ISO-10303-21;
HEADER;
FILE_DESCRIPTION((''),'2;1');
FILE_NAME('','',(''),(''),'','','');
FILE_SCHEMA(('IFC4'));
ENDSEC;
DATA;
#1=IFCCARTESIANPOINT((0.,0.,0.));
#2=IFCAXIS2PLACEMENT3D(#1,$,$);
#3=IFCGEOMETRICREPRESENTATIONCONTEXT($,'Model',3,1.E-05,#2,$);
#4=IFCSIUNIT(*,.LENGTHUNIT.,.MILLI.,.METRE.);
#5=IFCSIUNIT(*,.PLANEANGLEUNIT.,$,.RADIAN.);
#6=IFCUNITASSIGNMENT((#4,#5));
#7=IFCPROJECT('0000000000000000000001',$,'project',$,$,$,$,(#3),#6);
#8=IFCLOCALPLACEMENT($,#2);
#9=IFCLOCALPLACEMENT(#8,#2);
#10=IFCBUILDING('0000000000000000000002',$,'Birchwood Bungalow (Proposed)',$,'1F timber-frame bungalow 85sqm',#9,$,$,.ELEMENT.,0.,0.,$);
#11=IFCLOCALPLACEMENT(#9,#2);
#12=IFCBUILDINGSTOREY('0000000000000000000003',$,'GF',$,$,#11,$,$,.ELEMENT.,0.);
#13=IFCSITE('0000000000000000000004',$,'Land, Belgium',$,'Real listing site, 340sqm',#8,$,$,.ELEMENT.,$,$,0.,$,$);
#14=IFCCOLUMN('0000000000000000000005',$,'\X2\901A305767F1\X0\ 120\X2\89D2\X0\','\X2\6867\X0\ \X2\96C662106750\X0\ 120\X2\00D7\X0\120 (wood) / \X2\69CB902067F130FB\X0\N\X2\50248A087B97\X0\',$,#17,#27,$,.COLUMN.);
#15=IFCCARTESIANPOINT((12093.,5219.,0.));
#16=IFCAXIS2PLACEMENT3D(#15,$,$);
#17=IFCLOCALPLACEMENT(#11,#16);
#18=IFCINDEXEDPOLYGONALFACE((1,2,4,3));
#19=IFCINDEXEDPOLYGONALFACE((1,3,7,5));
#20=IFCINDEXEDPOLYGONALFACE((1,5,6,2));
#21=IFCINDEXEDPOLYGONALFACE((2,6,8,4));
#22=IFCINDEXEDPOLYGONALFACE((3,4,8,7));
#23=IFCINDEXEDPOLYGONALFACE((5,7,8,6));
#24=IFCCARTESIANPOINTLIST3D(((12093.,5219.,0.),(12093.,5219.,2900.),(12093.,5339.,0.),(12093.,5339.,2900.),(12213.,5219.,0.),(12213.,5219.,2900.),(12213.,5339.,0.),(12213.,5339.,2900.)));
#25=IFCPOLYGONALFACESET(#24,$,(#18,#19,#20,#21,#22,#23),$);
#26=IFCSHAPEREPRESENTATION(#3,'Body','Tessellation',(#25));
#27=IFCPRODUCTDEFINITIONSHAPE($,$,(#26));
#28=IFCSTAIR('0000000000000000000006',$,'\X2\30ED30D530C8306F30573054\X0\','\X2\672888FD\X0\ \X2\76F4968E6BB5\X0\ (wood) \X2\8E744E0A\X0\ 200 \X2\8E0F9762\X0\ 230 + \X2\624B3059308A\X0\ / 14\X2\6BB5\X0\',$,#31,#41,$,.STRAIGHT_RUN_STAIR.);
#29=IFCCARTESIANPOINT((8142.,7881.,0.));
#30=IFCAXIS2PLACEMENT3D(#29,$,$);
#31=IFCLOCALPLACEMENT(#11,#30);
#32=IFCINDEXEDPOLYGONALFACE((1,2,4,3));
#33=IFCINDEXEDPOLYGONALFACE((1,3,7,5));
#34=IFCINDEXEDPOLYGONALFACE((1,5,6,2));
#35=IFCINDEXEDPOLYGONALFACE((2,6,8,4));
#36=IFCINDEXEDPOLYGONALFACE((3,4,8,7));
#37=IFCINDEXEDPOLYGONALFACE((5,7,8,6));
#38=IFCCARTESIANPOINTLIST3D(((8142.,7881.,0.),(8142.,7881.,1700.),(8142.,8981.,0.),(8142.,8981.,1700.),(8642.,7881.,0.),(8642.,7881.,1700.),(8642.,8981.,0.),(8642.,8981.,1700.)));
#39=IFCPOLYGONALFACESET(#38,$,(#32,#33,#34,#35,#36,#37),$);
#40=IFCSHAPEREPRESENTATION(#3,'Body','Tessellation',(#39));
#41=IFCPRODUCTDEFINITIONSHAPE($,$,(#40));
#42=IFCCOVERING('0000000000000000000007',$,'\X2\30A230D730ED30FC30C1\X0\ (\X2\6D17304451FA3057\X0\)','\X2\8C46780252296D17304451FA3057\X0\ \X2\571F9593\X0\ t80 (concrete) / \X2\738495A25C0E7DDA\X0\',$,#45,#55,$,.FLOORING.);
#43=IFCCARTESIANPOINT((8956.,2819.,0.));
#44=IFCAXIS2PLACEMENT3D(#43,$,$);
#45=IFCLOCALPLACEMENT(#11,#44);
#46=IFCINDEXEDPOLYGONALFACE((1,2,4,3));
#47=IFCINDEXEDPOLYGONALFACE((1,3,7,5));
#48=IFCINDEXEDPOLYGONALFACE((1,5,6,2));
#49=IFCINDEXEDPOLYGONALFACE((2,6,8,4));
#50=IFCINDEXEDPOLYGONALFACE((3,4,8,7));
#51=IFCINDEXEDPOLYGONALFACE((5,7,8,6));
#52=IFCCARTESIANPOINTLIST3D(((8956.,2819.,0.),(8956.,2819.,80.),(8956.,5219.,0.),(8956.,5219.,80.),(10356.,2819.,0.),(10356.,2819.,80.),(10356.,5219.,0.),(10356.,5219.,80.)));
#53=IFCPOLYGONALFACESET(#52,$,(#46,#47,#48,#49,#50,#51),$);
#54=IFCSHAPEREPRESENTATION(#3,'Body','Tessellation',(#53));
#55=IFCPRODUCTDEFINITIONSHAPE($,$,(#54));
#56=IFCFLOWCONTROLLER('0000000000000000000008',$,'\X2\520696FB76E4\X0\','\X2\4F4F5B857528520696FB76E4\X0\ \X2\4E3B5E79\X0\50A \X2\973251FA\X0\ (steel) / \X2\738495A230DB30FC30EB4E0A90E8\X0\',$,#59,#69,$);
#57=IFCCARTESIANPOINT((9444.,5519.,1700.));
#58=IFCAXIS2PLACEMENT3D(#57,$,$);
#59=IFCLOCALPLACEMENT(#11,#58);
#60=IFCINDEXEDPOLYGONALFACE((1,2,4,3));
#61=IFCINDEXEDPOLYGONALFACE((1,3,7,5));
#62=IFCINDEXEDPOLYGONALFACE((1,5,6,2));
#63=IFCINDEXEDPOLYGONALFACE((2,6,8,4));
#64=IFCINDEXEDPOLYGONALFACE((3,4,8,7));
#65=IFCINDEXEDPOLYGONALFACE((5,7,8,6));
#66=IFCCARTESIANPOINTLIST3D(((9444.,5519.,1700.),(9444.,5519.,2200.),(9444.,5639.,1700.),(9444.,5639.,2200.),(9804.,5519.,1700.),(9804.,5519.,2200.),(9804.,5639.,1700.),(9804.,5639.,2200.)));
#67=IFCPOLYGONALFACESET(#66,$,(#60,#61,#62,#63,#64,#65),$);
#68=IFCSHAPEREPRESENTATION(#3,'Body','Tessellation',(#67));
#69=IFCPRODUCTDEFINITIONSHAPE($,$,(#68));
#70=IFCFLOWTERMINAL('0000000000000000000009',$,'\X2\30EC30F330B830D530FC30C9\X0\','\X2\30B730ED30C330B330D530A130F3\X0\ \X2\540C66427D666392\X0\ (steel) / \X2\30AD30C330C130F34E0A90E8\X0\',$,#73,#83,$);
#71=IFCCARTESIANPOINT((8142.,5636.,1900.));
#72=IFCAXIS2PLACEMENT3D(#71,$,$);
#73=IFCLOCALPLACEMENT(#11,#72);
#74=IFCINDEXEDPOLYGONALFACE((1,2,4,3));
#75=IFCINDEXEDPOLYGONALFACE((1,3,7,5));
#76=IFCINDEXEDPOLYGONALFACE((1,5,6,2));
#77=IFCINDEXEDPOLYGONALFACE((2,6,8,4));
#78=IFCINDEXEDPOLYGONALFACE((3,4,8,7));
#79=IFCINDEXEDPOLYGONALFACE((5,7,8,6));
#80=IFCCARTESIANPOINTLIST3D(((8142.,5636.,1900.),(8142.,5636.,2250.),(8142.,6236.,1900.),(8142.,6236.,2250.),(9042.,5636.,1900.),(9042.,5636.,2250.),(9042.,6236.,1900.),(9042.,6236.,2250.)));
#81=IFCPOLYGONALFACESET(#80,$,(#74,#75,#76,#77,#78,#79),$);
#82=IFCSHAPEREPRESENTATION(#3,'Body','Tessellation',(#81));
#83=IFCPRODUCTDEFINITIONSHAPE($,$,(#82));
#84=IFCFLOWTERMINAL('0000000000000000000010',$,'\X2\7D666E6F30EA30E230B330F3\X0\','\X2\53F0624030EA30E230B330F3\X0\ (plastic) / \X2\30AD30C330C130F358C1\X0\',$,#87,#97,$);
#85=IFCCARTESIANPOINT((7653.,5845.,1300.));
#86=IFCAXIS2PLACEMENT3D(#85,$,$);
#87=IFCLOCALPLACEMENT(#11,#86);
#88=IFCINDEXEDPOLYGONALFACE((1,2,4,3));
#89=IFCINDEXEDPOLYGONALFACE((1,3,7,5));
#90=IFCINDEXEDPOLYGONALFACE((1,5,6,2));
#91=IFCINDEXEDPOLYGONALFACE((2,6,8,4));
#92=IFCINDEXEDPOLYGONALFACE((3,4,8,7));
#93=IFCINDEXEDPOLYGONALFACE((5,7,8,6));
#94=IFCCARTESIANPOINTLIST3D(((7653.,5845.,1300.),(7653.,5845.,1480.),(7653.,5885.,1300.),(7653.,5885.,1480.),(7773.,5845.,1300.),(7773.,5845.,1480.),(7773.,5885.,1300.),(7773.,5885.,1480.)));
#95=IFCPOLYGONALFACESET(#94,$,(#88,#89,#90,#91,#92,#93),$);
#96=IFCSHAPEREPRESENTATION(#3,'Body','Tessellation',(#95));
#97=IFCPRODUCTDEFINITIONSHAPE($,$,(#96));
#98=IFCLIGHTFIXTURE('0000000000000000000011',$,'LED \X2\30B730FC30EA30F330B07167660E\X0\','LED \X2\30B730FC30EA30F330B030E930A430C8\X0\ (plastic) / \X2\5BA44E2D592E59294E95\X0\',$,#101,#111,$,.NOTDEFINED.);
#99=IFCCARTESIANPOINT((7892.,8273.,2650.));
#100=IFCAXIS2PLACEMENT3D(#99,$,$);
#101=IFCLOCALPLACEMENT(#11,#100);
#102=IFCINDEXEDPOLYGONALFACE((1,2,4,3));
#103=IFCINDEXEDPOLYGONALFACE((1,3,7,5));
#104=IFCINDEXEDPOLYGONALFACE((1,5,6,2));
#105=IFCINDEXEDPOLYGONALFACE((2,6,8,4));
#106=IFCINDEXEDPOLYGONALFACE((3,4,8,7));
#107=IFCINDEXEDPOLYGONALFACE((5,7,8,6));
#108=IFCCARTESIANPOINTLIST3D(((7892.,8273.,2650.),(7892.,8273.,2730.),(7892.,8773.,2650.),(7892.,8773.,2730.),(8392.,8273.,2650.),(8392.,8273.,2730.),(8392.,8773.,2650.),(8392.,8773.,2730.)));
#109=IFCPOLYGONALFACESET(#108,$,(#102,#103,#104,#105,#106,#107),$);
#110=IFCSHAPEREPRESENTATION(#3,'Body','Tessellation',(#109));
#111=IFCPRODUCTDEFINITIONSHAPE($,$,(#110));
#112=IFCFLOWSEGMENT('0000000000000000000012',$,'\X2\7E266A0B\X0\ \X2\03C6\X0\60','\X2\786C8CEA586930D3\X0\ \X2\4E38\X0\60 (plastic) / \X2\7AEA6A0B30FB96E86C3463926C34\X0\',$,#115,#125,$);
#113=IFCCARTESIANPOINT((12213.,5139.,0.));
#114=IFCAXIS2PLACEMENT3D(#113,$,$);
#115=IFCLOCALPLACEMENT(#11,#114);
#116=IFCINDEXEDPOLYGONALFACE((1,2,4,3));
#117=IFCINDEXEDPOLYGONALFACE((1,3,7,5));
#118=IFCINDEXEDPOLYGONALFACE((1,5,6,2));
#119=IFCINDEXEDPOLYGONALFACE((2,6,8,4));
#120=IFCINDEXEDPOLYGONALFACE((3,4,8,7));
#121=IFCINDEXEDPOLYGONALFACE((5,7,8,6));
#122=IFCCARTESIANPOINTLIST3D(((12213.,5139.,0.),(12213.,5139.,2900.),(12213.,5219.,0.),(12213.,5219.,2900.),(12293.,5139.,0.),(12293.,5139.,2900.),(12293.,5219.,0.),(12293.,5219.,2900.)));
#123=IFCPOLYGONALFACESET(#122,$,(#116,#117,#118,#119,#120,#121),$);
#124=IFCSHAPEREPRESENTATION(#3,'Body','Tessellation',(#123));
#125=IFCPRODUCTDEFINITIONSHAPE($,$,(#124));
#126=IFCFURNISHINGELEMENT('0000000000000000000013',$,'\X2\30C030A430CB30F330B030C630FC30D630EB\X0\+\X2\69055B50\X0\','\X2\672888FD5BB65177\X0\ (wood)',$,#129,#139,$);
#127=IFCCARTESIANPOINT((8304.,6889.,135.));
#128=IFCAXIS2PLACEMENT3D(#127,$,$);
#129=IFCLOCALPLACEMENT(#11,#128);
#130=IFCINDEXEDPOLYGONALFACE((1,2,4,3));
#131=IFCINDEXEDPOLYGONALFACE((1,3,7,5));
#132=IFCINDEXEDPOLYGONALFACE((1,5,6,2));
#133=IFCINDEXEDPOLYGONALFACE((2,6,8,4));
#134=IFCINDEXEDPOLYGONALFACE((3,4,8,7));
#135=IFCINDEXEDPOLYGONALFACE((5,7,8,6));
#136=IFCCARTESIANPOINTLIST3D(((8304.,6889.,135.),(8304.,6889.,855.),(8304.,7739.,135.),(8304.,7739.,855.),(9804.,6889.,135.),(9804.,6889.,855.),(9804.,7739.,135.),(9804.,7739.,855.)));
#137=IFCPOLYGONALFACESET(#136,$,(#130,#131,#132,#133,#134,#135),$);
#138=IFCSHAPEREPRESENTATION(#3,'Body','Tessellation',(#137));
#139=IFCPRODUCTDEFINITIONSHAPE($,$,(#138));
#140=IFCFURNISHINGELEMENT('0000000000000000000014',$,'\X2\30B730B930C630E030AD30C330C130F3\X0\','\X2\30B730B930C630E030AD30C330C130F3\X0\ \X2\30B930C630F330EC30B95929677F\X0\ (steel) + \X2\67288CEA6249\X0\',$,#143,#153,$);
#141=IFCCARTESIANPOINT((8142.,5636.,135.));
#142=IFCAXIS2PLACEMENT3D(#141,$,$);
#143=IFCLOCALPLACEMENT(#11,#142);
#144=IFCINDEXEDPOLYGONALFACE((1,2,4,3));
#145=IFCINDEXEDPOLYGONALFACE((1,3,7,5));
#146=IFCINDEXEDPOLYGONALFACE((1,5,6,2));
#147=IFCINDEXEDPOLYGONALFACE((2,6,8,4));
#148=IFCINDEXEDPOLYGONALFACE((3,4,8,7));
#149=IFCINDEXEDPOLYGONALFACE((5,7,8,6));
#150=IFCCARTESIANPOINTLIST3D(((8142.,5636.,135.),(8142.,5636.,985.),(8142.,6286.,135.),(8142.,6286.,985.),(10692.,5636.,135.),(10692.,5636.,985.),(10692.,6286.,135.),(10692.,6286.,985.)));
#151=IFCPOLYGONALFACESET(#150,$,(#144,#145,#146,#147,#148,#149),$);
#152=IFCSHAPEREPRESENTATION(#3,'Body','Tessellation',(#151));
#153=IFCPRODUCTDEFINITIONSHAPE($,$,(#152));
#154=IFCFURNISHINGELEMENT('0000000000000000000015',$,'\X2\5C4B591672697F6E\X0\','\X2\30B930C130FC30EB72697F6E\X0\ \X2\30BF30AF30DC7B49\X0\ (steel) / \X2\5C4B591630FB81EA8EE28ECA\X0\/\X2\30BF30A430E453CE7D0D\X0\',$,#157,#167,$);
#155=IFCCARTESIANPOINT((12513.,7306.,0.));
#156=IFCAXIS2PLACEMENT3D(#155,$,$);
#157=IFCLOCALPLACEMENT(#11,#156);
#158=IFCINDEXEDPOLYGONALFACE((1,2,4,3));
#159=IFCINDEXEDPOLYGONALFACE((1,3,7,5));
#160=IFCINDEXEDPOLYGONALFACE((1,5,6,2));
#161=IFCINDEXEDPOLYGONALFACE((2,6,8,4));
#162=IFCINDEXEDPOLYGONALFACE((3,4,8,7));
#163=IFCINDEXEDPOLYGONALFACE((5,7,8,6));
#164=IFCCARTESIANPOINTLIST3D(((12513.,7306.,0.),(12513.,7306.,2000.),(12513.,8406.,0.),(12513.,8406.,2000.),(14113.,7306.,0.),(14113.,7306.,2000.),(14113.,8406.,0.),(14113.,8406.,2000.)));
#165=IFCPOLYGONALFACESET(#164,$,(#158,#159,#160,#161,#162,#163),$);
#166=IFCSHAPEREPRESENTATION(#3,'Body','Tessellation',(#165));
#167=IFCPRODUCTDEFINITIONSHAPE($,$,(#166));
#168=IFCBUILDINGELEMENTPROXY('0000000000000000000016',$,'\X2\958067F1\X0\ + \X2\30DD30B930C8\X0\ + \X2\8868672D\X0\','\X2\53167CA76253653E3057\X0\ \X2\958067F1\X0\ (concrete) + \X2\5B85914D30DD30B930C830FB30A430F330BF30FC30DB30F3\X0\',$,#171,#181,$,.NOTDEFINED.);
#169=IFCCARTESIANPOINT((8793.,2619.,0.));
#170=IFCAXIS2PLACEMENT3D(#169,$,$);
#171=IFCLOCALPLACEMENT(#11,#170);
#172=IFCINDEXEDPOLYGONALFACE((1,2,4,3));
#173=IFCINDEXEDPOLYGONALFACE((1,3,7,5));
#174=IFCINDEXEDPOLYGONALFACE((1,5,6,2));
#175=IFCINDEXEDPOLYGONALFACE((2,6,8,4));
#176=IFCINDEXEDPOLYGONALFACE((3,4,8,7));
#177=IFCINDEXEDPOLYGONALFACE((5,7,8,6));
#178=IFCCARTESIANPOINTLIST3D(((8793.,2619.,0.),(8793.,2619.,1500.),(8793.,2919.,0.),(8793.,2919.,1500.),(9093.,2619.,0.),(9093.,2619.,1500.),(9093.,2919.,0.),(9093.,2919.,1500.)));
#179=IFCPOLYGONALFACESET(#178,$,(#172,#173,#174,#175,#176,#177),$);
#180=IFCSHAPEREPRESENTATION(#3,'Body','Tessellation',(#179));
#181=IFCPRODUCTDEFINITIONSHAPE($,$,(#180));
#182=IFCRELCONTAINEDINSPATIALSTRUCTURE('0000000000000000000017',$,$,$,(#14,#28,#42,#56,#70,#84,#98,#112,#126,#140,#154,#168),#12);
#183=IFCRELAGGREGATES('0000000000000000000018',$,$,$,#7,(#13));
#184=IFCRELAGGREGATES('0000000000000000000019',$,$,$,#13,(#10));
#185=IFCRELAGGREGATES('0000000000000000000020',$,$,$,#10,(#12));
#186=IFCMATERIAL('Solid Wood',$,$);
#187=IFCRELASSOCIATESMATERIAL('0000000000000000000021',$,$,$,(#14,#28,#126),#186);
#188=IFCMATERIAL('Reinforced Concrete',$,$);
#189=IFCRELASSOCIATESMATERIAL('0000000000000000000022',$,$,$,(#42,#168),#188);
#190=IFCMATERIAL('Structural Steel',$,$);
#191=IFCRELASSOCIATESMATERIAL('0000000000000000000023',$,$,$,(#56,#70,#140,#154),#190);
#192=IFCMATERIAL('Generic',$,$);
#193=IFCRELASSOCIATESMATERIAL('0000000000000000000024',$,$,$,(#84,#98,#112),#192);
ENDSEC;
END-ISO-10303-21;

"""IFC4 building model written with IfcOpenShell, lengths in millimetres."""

from ifc_helpers import new_model, si_unit, frame, frame_2d, origin, place, context, project, spatial, rectangle, extrude, material, element, save


model = new_model("IFC4")

# Units and contexts
model_context = context("Model", 3, precision=1e-05, world=origin())
ifc_project = project(units=[si_unit("LENGTHUNIT", "METRE", prefix="MILLI"), si_unit("PLANEANGLEUNIT", "RADIAN")], contexts=[model_context])

# Site, building, storey
site_placement = place(None, origin())
site = spatial("IfcSite", under=ifc_project, at=site_placement, Name="Land, Belgium", ObjectType="Real listing site, 340sqm", CompositionType="ELEMENT", RefElevation=0.0)
building_placement = place(site_placement, origin())
building = spatial("IfcBuilding", under=site, at=building_placement, Name="Birchwood Bungalow (Proposed)", ObjectType="1F timber-frame bungalow 85sqm", CompositionType="ELEMENT", ElevationOfRefHeight=0.0, ElevationOfTerrain=0.0)
storey_placement = place(building_placement, origin())
storey = spatial("IfcBuildingStorey", under=building, at=storey_placement, Name="GF", CompositionType="ELEMENT", Elevation=0.0)

# Column
ifc_material_1 = material(Name="Solid Wood")
column_1_placement = place(storey_placement, frame((12093.0, 5219.0, 0.0)))
element("IfcColumn", 1, at=column_1_placement, inside=storey, material=ifc_material_1, Name="通し柱 120角", Description="桧 集成材 120×120 (wood) / 構造柱・N値計算", PredefinedType="COLUMN", context=model_context, shape_type="SweptSolid", body=[
    extrude(rectangle(XDim=120.0, YDim=120.0, at=frame_2d((60.0, 60.0))), frame((12093.0, 5219.0, 0.0)), (0.0, 0.0, 1.0), 2900.0),
])

# Stair
stair_placement = place(storey_placement, frame((8142.0, 7881.0, 0.0)))
element("IfcStair", 2, at=stair_placement, inside=storey, material=ifc_material_1, Name="ロフトはしご", Description="木製 直階段 (wood) 蹴上 200 踏面 230 + 手すり / 14段", PredefinedType="STRAIGHT_RUN_STAIR", context=model_context, shape_type="SweptSolid", body=[
    extrude(rectangle(XDim=500.0, YDim=1100.0, at=frame_2d((250.0, 550.0))), frame((8142.0, 7881.0, 0.0)), (0.0, 0.0, 1.0), 1700.0),
])

# Covering
ifc_material_2 = material(Name="Reinforced Concrete")
covering_placement = place(storey_placement, frame((8956.0, 2819.0, 0.0)))
element("IfcCovering", 3, at=covering_placement, inside=storey, material=ifc_material_2, Name="アプローチ (洗い出し)", Description="豆砂利洗い出し 土間 t80 (concrete) / 玄関導線", PredefinedType="FLOORING", context=model_context, shape_type="SweptSolid", body=[
    extrude(rectangle(XDim=1400.0, YDim=2400.0, at=frame_2d((700.0, 1200.0))), frame((8956.0, 2819.0, 0.0)), (0.0, 0.0, 1.0), 80.0),
])

# Flow controller
ifc_material_3 = material(Name="Structural Steel")
flow_controller_placement = place(storey_placement, frame((9444.0, 5519.0, 1700.0)))
element("IfcFlowController", 4, at=flow_controller_placement, inside=storey, material=ifc_material_3, Name="分電盤", Description="住宅用分電盤 主幹50A 露出 (steel) / 玄関ホール上部", context=model_context, shape_type="SweptSolid", body=[
    extrude(rectangle(XDim=360.0, YDim=120.0, at=frame_2d((180.0, 60.0))), frame((9444.0, 5519.0, 1700.0)), (0.0, 0.0, 1.0), 500.0),
])

# Flow terminals
flow_terminal_1_placement = place(storey_placement, frame((8142.0, 5636.0, 1900.0)))
element("IfcFlowTerminal", 5, at=flow_terminal_1_placement, inside=storey, material=ifc_material_3, Name="レンジフード", Description="シロッコファン 同時給排 (steel) / キッチン上部", context=model_context, shape_type="SweptSolid", body=[
    extrude(rectangle(XDim=900.0, YDim=600.0, at=frame_2d((450.0, 300.0))), frame((8142.0, 5636.0, 1900.0)), (0.0, 0.0, 1.0), 350.0),
])
ifc_material_4 = material(Name="Generic")
flow_terminal_2_placement = place(storey_placement, frame((7653.0, 5845.0, 1300.0)))
element("IfcFlowTerminal", 6, at=flow_terminal_2_placement, inside=storey, material=ifc_material_4, Name="給湯リモコン", Description="台所リモコン (plastic) / キッチン壁", context=model_context, shape_type="SweptSolid", body=[
    extrude(rectangle(XDim=120.0, YDim=40.0, at=frame_2d((60.0, 20.0))), frame((7653.0, 5845.0, 1300.0)), (0.0, 0.0, 1.0), 180.0),
])

# Light fixture
light_fixture_placement = place(storey_placement, frame((7892.0, 8273.0, 2650.0)))
element("IfcLightFixture", 7, at=light_fixture_placement, inside=storey, material=ifc_material_4, Name="LED シーリング照明", Description="LED シーリングライト (plastic) / 室中央天井", PredefinedType="NOTDEFINED", context=model_context, shape_type="SweptSolid", body=[
    extrude(rectangle(XDim=500.0, YDim=500.0, at=frame_2d((250.0, 250.0))), frame((7892.0, 8273.0, 2650.0)), (0.0, 0.0, 1.0), 80.0),
])

# Flow segment
flow_segment_placement = place(storey_placement, frame((12213.0, 5139.0, 0.0)))
element("IfcFlowSegment", 8, at=flow_segment_placement, inside=storey, material=ifc_material_4, Name="縦樋 φ60", Description="硬質塩ビ 丸60 (plastic) / 竪樋・雨水排水", context=model_context, shape_type="SweptSolid", body=[
    extrude(rectangle(XDim=80.0, YDim=80.0, at=frame_2d((40.0, 40.0))), frame((12213.0, 5139.0, 0.0)), (0.0, 0.0, 1.0), 2900.0),
])

# Furnishing elements
furnishing_1_placement = place(storey_placement, frame((8304.0, 6889.0, 135.0)))
element("IfcFurnishingElement", 9, at=furnishing_1_placement, inside=storey, material=ifc_material_1, Name="ダイニングテーブル+椅子", Description="木製家具 (wood)", context=model_context, shape_type="SweptSolid", body=[
    extrude(rectangle(XDim=1500.0, YDim=850.0, at=frame_2d((750.0, 425.0))), frame((8304.0, 6889.0, 135.0)), (0.0, 0.0, 1.0), 720.0),
])
furnishing_2_placement = place(storey_placement, frame((8142.0, 5636.0, 135.0)))
element("IfcFurnishingElement", 10, at=furnishing_2_placement, inside=storey, material=ifc_material_3, Name="システムキッチン", Description="システムキッチン ステンレス天板 (steel) + 木質扉", context=model_context, shape_type="SweptSolid", body=[
    extrude(rectangle(XDim=2550.0, YDim=650.0, at=frame_2d((1275.0, 325.0))), frame((8142.0, 5636.0, 135.0)), (0.0, 0.0, 1.0), 850.0),
])
furnishing_3_placement = place(storey_placement, frame((12513.0, 7306.0, 0.0)))
element("IfcFurnishingElement", 11, at=furnishing_3_placement, inside=storey, material=ifc_material_3, Name="屋外物置", Description="スチール物置 タクボ等 (steel) / 屋外・自転車/タイヤ収納", context=model_context, shape_type="SweptSolid", body=[
    extrude(rectangle(XDim=1600.0, YDim=1100.0, at=frame_2d((800.0, 550.0))), frame((12513.0, 7306.0, 0.0)), (0.0, 0.0, 1.0), 2000.0),
])

# Building element proxy
proxy_placement = place(storey_placement, frame((8793.0, 2619.0, 0.0)))
element("IfcBuildingElementProxy", 12, at=proxy_placement, inside=storey, material=ifc_material_2, Name="門柱 + ポスト + 表札", Description="化粧打放し 門柱 (concrete) + 宅配ポスト・インターホン", PredefinedType="NOTDEFINED", context=model_context, shape_type="SweptSolid", body=[
    extrude(rectangle(XDim=300.0, YDim=300.0, at=frame_2d((150.0, 150.0))), frame((8793.0, 2619.0, 0.0)), (0.0, 0.0, 1.0), 1500.0),
])

save(model, "model.ifc")
